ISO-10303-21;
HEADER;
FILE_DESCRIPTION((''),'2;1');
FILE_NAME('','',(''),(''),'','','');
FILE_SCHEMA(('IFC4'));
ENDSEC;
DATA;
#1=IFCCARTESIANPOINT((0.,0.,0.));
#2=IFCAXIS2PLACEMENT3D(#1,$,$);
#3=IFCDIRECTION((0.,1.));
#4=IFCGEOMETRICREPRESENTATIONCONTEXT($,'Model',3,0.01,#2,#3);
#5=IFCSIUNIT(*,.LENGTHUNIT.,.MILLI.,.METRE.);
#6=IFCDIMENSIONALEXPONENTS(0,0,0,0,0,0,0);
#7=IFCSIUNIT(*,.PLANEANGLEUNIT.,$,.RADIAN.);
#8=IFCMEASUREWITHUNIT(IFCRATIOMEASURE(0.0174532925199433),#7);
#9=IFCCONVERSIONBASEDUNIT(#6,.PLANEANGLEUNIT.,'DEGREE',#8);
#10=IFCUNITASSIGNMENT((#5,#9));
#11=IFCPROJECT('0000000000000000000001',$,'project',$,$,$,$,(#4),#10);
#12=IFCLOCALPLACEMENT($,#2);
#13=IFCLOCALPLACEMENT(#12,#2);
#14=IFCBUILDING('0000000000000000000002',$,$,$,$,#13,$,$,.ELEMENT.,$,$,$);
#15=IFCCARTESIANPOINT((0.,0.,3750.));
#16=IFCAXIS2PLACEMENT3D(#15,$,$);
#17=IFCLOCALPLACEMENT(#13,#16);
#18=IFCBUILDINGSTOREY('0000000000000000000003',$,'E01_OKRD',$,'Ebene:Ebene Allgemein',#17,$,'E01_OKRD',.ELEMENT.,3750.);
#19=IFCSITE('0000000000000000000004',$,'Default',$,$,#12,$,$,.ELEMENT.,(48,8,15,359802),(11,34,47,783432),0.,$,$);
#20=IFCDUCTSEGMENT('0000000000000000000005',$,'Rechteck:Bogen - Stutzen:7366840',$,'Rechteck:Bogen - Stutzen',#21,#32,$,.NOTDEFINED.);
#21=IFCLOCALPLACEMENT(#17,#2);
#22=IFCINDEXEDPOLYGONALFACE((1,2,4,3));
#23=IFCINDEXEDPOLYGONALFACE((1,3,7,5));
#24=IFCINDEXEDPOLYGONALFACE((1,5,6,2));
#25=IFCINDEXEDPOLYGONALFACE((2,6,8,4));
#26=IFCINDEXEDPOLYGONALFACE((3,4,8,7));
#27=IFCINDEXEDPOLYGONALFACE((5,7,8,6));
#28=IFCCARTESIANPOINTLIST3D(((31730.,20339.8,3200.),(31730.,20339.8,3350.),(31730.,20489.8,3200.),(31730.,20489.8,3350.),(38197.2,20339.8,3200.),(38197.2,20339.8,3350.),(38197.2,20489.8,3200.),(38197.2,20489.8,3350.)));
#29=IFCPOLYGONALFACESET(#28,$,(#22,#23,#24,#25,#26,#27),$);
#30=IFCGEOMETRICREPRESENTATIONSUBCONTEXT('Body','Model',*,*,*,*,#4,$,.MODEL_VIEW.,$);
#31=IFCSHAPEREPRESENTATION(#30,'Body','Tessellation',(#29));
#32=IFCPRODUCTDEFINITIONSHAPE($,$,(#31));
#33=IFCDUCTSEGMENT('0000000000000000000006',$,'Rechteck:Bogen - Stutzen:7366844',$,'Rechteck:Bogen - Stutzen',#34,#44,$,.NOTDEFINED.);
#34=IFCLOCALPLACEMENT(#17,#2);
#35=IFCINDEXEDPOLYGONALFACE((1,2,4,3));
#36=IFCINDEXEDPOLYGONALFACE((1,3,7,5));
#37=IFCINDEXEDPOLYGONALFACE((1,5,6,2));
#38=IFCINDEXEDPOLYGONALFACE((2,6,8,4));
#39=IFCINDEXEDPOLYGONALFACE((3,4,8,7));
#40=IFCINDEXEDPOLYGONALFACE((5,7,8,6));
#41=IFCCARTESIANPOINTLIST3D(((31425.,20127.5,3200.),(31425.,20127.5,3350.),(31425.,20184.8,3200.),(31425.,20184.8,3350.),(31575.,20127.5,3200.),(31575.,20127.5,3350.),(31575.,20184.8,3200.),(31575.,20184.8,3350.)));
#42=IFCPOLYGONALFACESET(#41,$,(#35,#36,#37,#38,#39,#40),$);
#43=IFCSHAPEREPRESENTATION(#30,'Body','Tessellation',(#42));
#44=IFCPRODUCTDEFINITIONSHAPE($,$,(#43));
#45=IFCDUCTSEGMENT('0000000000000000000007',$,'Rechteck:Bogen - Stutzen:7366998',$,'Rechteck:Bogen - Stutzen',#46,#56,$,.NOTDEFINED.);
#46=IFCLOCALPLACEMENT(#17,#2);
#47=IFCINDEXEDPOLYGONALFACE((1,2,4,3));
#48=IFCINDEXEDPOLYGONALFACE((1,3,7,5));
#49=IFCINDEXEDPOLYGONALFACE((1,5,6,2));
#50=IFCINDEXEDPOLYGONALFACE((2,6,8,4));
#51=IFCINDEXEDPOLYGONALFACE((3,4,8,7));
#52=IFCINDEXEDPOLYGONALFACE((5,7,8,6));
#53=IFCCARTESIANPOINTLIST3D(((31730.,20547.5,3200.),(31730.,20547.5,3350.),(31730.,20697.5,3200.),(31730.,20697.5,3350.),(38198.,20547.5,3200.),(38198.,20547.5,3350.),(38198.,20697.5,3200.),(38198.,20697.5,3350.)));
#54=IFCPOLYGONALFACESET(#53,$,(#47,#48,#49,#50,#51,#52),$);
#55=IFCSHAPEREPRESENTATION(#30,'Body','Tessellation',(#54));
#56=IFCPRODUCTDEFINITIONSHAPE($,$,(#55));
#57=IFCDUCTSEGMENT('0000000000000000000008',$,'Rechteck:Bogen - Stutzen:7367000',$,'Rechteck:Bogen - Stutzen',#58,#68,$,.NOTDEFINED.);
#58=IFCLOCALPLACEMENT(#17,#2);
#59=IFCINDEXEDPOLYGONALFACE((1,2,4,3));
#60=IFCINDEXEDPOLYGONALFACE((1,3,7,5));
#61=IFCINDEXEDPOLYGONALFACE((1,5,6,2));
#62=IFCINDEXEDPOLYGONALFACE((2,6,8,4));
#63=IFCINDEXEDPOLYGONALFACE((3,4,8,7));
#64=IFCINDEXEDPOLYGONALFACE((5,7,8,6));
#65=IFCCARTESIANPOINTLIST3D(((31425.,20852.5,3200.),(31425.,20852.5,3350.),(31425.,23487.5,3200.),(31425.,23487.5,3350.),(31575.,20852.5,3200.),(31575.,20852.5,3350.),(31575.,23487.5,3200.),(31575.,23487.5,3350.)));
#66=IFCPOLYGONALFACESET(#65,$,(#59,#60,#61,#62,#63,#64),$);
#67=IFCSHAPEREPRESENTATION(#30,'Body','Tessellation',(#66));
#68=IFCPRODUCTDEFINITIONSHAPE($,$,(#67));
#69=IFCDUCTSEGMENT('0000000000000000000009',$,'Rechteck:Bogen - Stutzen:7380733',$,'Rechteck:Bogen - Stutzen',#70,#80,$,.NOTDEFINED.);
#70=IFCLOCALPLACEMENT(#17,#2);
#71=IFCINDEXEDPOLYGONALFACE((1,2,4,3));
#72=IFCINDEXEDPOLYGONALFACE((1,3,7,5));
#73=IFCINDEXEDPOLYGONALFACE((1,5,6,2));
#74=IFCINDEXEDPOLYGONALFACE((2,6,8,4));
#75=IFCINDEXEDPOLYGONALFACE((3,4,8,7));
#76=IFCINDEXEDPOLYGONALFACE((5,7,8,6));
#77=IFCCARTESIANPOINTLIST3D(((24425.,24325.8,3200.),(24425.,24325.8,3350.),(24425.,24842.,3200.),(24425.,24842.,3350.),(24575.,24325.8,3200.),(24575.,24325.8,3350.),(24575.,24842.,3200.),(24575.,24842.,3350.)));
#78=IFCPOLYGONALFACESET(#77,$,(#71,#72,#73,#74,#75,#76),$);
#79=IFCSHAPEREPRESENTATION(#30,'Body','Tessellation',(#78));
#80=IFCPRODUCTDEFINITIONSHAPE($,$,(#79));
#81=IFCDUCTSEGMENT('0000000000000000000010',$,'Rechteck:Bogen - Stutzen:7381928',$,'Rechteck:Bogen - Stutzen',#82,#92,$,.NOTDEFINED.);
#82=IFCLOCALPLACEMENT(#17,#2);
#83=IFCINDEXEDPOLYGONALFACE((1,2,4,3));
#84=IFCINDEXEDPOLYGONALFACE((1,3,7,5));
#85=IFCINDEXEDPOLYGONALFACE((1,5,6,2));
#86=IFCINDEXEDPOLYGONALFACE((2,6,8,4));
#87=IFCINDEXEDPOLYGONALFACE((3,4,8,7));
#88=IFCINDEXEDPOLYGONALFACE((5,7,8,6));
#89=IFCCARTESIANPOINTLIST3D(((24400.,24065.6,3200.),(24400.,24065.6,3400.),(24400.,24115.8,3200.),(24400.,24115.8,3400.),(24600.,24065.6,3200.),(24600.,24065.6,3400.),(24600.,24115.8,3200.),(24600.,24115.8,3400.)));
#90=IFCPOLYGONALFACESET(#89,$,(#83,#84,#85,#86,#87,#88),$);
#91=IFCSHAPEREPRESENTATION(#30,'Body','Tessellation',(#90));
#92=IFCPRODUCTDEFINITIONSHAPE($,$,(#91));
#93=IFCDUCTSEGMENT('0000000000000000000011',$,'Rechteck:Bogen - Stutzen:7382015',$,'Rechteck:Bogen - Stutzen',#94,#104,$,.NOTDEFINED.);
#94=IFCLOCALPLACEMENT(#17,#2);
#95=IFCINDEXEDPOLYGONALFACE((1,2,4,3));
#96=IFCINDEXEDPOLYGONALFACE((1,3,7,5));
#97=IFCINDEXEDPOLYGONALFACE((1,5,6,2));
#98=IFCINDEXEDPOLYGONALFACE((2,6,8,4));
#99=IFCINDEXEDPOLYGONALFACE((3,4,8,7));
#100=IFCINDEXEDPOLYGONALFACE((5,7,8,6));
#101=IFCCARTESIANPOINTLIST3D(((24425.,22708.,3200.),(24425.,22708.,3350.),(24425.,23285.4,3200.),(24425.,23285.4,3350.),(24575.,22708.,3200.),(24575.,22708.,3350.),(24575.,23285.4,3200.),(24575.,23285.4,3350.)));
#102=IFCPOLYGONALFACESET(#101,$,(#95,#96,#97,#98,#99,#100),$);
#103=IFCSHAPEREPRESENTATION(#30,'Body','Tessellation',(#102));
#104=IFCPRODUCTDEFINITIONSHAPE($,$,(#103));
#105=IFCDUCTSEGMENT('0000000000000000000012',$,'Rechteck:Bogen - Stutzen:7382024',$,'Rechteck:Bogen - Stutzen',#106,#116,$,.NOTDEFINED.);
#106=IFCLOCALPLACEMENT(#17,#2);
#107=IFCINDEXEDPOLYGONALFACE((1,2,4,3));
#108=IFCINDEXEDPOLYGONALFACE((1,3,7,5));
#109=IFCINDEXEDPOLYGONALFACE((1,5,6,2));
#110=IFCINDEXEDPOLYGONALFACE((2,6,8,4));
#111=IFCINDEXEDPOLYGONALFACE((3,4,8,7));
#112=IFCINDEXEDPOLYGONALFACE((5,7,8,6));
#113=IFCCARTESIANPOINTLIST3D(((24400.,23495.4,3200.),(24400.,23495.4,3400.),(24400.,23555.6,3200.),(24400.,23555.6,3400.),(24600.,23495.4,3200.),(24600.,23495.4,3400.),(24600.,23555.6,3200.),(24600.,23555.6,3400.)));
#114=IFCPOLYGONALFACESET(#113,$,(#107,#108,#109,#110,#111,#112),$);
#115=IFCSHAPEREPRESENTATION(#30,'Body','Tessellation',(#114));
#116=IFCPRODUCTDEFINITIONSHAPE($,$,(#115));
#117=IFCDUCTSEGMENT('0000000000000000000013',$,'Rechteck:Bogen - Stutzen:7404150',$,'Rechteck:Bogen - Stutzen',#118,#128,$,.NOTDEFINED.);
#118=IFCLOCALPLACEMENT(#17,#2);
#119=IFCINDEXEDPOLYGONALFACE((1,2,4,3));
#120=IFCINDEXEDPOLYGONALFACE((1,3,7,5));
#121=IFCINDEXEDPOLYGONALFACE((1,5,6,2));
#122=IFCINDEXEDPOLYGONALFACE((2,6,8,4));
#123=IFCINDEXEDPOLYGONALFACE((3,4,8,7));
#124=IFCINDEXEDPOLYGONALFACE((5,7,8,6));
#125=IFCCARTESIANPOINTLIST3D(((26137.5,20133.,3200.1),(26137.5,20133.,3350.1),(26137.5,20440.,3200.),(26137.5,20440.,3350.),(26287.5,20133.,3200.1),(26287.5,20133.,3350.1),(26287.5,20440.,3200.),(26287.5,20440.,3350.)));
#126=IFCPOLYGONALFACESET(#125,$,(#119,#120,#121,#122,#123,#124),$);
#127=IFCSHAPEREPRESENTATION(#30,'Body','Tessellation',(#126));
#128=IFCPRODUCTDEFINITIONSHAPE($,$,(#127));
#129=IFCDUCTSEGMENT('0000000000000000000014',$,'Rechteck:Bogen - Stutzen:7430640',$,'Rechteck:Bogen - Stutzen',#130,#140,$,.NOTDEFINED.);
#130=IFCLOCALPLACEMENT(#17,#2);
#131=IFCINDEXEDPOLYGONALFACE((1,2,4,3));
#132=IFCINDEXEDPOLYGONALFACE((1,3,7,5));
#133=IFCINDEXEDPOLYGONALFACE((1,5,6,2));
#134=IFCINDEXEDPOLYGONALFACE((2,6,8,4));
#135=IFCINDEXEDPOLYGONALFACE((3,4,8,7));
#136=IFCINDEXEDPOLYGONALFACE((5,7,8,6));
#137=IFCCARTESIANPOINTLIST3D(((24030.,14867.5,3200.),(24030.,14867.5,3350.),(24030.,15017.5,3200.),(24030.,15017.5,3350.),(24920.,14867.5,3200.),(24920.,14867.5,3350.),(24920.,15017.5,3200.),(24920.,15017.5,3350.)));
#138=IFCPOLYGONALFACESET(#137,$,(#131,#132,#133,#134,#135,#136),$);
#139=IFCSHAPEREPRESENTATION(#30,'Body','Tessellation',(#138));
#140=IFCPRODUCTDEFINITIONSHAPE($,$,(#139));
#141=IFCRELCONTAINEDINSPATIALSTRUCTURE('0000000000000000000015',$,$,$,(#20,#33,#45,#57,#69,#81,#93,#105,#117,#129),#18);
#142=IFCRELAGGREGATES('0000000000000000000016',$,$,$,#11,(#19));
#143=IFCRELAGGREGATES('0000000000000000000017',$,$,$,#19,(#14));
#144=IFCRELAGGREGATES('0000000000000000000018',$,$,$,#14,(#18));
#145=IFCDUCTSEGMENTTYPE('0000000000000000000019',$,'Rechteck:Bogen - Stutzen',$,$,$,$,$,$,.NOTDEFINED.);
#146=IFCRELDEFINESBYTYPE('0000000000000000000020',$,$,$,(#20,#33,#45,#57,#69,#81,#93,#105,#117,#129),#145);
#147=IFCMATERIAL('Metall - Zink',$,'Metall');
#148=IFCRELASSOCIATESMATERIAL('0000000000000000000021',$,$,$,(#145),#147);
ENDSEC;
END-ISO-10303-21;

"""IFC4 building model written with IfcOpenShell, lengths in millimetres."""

from ifc_helpers import new_model, entity, si_unit, converted_unit, direction, frame, frame_2d, origin, origin_2d_with_axis, place, context, subcontext, project, spatial, rectangle, extrude, material, type_object, element, save


model = new_model("IFC4")

# Units and contexts
model_context = context("Model", 3, precision=0.01, world=origin(), true_north=direction((0.0, 1.0)))
body_context = subcontext(model_context, "Body", "Model", "MODEL_VIEW")
ifc_project = project(units=[si_unit("LENGTHUNIT", "METRE", prefix="MILLI"), converted_unit("PLANEANGLEUNIT", "DEGREE", entity("IfcRatioMeasure", 0.0174532925199433), si_unit("PLANEANGLEUNIT", "RADIAN"), dimensions=[0, 0, 0, 0, 0, 0, 0])], contexts=[model_context])

# Site, building, storey
site_placement = place(None, origin())
site = spatial("IfcSite", under=ifc_project, at=site_placement, Name="Default", CompositionType="ELEMENT", RefLatitude=(48, 8, 15, 359802), RefLongitude=(11, 34, 47, 783432), RefElevation=0.0)
building_placement = place(site_placement, origin())
building = spatial("IfcBuilding", under=site, at=building_placement, CompositionType="ELEMENT")
storey_placement = place(building_placement, frame((0.0, 0.0, 3750.0)))
storey = spatial("IfcBuildingStorey", under=building, at=storey_placement, Name="E01_OKRD", ObjectType="Ebene:Ebene Allgemein", LongName="E01_OKRD", CompositionType="ELEMENT", Elevation=3750.0)

# Duct segments
ifc_material_1 = material(Name="Metall - Zink", Category="Metall")
duct_segment_type_1 = type_object("IfcDuctSegmentType", Name="Rechteck:Bogen - Stutzen", PredefinedType="NOTDEFINED", material=ifc_material_1)
duct_segment_1_placement = place(storey_placement, frame((31730.0, 20339.8, 3200.0)))
element("IfcDuctSegment", 1, at=duct_segment_1_placement, inside=storey, type_object=duct_segment_type_1, Name="Rechteck:Bogen - Stutzen:7366840", ObjectType="Rechteck:Bogen - Stutzen", PredefinedType="NOTDEFINED", context=body_context, shape_type="SweptSolid", body=[
    extrude(rectangle(XDim=6467.2, YDim=150.0, at=frame_2d((0.0, 0.0), x_axis=(1.0, 0.0))), frame((3233.6, 75.0, 0.0)), (0.0, 0.0, 1.0), 150.0),
])
duct_segment_2_placement = place(storey_placement, frame((31425.0, 20127.5, 3200.0)))
element("IfcDuctSegment", 2, at=duct_segment_2_placement, inside=storey, type_object=duct_segment_type_1, Name="Rechteck:Bogen - Stutzen:7366844", ObjectType="Rechteck:Bogen - Stutzen", PredefinedType="NOTDEFINED", context=body_context, shape_type="SweptSolid", body=[
    extrude(rectangle(XDim=57.3, YDim=150.0, at=frame_2d((0.0, 0.0), x_axis=(1.0, 0.0))), frame((75.0, 28.7, 0.0), z_axis=(0.0, 0.0, 1.0), x_axis=(0.0, 1.0, 0.0)), (0.0, 0.0, 1.0), 150.0),
])
duct_segment_3_placement = place(storey_placement, frame((31730.0, 20547.5, 3200.0)))
element("IfcDuctSegment", 3, at=duct_segment_3_placement, inside=storey, type_object=duct_segment_type_1, Name="Rechteck:Bogen - Stutzen:7366998", ObjectType="Rechteck:Bogen - Stutzen", PredefinedType="NOTDEFINED", context=body_context, shape_type="SweptSolid", body=[
    extrude(rectangle(XDim=6468.1, YDim=150.0, at=frame_2d((0.0, 0.0), x_axis=(1.0, 0.0))), frame((3234.0, 75.0, 0.0), z_axis=(0.0, 0.0, 1.0), x_axis=(-1.0, 0.0, 0.0)), (0.0, 0.0, 1.0), 150.0),
])
duct_segment_4_placement = place(storey_placement, frame((31425.0, 20852.5, 3200.0)))
element("IfcDuctSegment", 4, at=duct_segment_4_placement, inside=storey, type_object=duct_segment_type_1, Name="Rechteck:Bogen - Stutzen:7367000", ObjectType="Rechteck:Bogen - Stutzen", PredefinedType="NOTDEFINED", context=body_context, shape_type="SweptSolid", body=[
    extrude(rectangle(XDim=2635.0, YDim=150.0, at=frame_2d((0.0, 0.0), x_axis=(1.0, 0.0))), frame((75.0, 1317.5, 0.0), z_axis=(0.0, 0.0, 1.0), x_axis=(0.0, 1.0, 0.0)), (0.0, 0.0, 1.0), 150.0),
])
duct_segment_5_placement = place(storey_placement, frame((24425.0, 24325.8, 3200.0)))
element("IfcDuctSegment", 5, at=duct_segment_5_placement, inside=storey, type_object=duct_segment_type_1, Name="Rechteck:Bogen - Stutzen:7380733", ObjectType="Rechteck:Bogen - Stutzen", PredefinedType="NOTDEFINED", context=body_context, shape_type="SweptSolid", body=[
    extrude(rectangle(XDim=516.2, YDim=150.0, at=frame_2d((0.0, 0.0), x_axis=(1.0, 0.0))), frame((75.0, 258.1, 0.0), z_axis=(0.0, 0.0, 1.0), x_axis=(0.0, -1.0, 0.0)), (0.0, 0.0, 1.0), 150.0),
])
duct_segment_6_placement = place(storey_placement, frame((24400.0, 24065.6, 3200.0)))
element("IfcDuctSegment", 6, at=duct_segment_6_placement, inside=storey, type_object=duct_segment_type_1, Name="Rechteck:Bogen - Stutzen:7381928", ObjectType="Rechteck:Bogen - Stutzen", PredefinedType="NOTDEFINED", context=body_context, shape_type="SweptSolid", body=[
    extrude(rectangle(XDim=50.2, YDim=200.0, at=frame_2d((0.0, 0.0), x_axis=(1.0, 0.0))), frame((100.0, 25.1, 0.0), z_axis=(0.0, 0.0, 1.0), x_axis=(0.0, 1.0, 0.0)), (0.0, 0.0, 1.0), 200.0),
])
duct_segment_7_placement = place(storey_placement, frame((24425.0, 22708.0, 3200.0)))
element("IfcDuctSegment", 7, at=duct_segment_7_placement, inside=storey, type_object=duct_segment_type_1, Name="Rechteck:Bogen - Stutzen:7382015", ObjectType="Rechteck:Bogen - Stutzen", PredefinedType="NOTDEFINED", context=body_context, shape_type="SweptSolid", body=[
    extrude(rectangle(XDim=577.4, YDim=150.0, at=origin_2d_with_axis()), frame((75.0, 288.7, 0.0), z_axis=(0.0, 0.0, 1.0), x_axis=(0.0, -1.0, 0.0)), (0.0, 0.0, 1.0), 150.0),
])
duct_segment_8_placement = place(storey_placement, frame((24400.0, 23495.4, 3200.0)))
element("IfcDuctSegment", 8, at=duct_segment_8_placement, inside=storey, type_object=duct_segment_type_1, Name="Rechteck:Bogen - Stutzen:7382024", ObjectType="Rechteck:Bogen - Stutzen", PredefinedType="NOTDEFINED", context=body_context, shape_type="SweptSolid", body=[
    extrude(rectangle(XDim=60.2, YDim=200.0, at=origin_2d_with_axis()), frame((100.0, 30.1, 0.0), z_axis=(0.0, 0.0, 1.0), x_axis=(0.0, -1.0, 0.0)), (0.0, 0.0, 1.0), 200.0),
])
duct_segment_9_placement = place(storey_placement, frame((26137.5, 20133.0, 3200.0)))
element("IfcDuctSegment", 9, at=duct_segment_9_placement, inside=storey, type_object=duct_segment_type_1, Name="Rechteck:Bogen - Stutzen:7404150", ObjectType="Rechteck:Bogen - Stutzen", PredefinedType="NOTDEFINED", context=body_context, shape_type="SweptSolid", body=[
    extrude(rectangle(XDim=307.0, YDim=150.0, at=origin_2d_with_axis()), frame((75.0, 153.5, 0.0), z_axis=(0.0, 0.000174, 1.0), x_axis=(0.0, 1.0, -0.000174)), (0.0, 0.0, 1.0), 150.0),
])
duct_segment_10_placement = place(storey_placement, frame((24030.0, 14867.5, 3200.0)))
element("IfcDuctSegment", 10, at=duct_segment_10_placement, inside=storey, type_object=duct_segment_type_1, Name="Rechteck:Bogen - Stutzen:7430640", ObjectType="Rechteck:Bogen - Stutzen", PredefinedType="NOTDEFINED", context=body_context, shape_type="SweptSolid", body=[
    extrude(rectangle(XDim=890.0, YDim=150.0, at=frame_2d((0.0, 0.0), x_axis=(1.0, 0.0))), frame((445.0, 75.0, 0.0), z_axis=(-0.000017, 0.0, 1.0), x_axis=(-1.0, 0.0, -0.000017)), (0.0, 0.0, 1.0), 150.0),
])

save(model, "model.ifc")
